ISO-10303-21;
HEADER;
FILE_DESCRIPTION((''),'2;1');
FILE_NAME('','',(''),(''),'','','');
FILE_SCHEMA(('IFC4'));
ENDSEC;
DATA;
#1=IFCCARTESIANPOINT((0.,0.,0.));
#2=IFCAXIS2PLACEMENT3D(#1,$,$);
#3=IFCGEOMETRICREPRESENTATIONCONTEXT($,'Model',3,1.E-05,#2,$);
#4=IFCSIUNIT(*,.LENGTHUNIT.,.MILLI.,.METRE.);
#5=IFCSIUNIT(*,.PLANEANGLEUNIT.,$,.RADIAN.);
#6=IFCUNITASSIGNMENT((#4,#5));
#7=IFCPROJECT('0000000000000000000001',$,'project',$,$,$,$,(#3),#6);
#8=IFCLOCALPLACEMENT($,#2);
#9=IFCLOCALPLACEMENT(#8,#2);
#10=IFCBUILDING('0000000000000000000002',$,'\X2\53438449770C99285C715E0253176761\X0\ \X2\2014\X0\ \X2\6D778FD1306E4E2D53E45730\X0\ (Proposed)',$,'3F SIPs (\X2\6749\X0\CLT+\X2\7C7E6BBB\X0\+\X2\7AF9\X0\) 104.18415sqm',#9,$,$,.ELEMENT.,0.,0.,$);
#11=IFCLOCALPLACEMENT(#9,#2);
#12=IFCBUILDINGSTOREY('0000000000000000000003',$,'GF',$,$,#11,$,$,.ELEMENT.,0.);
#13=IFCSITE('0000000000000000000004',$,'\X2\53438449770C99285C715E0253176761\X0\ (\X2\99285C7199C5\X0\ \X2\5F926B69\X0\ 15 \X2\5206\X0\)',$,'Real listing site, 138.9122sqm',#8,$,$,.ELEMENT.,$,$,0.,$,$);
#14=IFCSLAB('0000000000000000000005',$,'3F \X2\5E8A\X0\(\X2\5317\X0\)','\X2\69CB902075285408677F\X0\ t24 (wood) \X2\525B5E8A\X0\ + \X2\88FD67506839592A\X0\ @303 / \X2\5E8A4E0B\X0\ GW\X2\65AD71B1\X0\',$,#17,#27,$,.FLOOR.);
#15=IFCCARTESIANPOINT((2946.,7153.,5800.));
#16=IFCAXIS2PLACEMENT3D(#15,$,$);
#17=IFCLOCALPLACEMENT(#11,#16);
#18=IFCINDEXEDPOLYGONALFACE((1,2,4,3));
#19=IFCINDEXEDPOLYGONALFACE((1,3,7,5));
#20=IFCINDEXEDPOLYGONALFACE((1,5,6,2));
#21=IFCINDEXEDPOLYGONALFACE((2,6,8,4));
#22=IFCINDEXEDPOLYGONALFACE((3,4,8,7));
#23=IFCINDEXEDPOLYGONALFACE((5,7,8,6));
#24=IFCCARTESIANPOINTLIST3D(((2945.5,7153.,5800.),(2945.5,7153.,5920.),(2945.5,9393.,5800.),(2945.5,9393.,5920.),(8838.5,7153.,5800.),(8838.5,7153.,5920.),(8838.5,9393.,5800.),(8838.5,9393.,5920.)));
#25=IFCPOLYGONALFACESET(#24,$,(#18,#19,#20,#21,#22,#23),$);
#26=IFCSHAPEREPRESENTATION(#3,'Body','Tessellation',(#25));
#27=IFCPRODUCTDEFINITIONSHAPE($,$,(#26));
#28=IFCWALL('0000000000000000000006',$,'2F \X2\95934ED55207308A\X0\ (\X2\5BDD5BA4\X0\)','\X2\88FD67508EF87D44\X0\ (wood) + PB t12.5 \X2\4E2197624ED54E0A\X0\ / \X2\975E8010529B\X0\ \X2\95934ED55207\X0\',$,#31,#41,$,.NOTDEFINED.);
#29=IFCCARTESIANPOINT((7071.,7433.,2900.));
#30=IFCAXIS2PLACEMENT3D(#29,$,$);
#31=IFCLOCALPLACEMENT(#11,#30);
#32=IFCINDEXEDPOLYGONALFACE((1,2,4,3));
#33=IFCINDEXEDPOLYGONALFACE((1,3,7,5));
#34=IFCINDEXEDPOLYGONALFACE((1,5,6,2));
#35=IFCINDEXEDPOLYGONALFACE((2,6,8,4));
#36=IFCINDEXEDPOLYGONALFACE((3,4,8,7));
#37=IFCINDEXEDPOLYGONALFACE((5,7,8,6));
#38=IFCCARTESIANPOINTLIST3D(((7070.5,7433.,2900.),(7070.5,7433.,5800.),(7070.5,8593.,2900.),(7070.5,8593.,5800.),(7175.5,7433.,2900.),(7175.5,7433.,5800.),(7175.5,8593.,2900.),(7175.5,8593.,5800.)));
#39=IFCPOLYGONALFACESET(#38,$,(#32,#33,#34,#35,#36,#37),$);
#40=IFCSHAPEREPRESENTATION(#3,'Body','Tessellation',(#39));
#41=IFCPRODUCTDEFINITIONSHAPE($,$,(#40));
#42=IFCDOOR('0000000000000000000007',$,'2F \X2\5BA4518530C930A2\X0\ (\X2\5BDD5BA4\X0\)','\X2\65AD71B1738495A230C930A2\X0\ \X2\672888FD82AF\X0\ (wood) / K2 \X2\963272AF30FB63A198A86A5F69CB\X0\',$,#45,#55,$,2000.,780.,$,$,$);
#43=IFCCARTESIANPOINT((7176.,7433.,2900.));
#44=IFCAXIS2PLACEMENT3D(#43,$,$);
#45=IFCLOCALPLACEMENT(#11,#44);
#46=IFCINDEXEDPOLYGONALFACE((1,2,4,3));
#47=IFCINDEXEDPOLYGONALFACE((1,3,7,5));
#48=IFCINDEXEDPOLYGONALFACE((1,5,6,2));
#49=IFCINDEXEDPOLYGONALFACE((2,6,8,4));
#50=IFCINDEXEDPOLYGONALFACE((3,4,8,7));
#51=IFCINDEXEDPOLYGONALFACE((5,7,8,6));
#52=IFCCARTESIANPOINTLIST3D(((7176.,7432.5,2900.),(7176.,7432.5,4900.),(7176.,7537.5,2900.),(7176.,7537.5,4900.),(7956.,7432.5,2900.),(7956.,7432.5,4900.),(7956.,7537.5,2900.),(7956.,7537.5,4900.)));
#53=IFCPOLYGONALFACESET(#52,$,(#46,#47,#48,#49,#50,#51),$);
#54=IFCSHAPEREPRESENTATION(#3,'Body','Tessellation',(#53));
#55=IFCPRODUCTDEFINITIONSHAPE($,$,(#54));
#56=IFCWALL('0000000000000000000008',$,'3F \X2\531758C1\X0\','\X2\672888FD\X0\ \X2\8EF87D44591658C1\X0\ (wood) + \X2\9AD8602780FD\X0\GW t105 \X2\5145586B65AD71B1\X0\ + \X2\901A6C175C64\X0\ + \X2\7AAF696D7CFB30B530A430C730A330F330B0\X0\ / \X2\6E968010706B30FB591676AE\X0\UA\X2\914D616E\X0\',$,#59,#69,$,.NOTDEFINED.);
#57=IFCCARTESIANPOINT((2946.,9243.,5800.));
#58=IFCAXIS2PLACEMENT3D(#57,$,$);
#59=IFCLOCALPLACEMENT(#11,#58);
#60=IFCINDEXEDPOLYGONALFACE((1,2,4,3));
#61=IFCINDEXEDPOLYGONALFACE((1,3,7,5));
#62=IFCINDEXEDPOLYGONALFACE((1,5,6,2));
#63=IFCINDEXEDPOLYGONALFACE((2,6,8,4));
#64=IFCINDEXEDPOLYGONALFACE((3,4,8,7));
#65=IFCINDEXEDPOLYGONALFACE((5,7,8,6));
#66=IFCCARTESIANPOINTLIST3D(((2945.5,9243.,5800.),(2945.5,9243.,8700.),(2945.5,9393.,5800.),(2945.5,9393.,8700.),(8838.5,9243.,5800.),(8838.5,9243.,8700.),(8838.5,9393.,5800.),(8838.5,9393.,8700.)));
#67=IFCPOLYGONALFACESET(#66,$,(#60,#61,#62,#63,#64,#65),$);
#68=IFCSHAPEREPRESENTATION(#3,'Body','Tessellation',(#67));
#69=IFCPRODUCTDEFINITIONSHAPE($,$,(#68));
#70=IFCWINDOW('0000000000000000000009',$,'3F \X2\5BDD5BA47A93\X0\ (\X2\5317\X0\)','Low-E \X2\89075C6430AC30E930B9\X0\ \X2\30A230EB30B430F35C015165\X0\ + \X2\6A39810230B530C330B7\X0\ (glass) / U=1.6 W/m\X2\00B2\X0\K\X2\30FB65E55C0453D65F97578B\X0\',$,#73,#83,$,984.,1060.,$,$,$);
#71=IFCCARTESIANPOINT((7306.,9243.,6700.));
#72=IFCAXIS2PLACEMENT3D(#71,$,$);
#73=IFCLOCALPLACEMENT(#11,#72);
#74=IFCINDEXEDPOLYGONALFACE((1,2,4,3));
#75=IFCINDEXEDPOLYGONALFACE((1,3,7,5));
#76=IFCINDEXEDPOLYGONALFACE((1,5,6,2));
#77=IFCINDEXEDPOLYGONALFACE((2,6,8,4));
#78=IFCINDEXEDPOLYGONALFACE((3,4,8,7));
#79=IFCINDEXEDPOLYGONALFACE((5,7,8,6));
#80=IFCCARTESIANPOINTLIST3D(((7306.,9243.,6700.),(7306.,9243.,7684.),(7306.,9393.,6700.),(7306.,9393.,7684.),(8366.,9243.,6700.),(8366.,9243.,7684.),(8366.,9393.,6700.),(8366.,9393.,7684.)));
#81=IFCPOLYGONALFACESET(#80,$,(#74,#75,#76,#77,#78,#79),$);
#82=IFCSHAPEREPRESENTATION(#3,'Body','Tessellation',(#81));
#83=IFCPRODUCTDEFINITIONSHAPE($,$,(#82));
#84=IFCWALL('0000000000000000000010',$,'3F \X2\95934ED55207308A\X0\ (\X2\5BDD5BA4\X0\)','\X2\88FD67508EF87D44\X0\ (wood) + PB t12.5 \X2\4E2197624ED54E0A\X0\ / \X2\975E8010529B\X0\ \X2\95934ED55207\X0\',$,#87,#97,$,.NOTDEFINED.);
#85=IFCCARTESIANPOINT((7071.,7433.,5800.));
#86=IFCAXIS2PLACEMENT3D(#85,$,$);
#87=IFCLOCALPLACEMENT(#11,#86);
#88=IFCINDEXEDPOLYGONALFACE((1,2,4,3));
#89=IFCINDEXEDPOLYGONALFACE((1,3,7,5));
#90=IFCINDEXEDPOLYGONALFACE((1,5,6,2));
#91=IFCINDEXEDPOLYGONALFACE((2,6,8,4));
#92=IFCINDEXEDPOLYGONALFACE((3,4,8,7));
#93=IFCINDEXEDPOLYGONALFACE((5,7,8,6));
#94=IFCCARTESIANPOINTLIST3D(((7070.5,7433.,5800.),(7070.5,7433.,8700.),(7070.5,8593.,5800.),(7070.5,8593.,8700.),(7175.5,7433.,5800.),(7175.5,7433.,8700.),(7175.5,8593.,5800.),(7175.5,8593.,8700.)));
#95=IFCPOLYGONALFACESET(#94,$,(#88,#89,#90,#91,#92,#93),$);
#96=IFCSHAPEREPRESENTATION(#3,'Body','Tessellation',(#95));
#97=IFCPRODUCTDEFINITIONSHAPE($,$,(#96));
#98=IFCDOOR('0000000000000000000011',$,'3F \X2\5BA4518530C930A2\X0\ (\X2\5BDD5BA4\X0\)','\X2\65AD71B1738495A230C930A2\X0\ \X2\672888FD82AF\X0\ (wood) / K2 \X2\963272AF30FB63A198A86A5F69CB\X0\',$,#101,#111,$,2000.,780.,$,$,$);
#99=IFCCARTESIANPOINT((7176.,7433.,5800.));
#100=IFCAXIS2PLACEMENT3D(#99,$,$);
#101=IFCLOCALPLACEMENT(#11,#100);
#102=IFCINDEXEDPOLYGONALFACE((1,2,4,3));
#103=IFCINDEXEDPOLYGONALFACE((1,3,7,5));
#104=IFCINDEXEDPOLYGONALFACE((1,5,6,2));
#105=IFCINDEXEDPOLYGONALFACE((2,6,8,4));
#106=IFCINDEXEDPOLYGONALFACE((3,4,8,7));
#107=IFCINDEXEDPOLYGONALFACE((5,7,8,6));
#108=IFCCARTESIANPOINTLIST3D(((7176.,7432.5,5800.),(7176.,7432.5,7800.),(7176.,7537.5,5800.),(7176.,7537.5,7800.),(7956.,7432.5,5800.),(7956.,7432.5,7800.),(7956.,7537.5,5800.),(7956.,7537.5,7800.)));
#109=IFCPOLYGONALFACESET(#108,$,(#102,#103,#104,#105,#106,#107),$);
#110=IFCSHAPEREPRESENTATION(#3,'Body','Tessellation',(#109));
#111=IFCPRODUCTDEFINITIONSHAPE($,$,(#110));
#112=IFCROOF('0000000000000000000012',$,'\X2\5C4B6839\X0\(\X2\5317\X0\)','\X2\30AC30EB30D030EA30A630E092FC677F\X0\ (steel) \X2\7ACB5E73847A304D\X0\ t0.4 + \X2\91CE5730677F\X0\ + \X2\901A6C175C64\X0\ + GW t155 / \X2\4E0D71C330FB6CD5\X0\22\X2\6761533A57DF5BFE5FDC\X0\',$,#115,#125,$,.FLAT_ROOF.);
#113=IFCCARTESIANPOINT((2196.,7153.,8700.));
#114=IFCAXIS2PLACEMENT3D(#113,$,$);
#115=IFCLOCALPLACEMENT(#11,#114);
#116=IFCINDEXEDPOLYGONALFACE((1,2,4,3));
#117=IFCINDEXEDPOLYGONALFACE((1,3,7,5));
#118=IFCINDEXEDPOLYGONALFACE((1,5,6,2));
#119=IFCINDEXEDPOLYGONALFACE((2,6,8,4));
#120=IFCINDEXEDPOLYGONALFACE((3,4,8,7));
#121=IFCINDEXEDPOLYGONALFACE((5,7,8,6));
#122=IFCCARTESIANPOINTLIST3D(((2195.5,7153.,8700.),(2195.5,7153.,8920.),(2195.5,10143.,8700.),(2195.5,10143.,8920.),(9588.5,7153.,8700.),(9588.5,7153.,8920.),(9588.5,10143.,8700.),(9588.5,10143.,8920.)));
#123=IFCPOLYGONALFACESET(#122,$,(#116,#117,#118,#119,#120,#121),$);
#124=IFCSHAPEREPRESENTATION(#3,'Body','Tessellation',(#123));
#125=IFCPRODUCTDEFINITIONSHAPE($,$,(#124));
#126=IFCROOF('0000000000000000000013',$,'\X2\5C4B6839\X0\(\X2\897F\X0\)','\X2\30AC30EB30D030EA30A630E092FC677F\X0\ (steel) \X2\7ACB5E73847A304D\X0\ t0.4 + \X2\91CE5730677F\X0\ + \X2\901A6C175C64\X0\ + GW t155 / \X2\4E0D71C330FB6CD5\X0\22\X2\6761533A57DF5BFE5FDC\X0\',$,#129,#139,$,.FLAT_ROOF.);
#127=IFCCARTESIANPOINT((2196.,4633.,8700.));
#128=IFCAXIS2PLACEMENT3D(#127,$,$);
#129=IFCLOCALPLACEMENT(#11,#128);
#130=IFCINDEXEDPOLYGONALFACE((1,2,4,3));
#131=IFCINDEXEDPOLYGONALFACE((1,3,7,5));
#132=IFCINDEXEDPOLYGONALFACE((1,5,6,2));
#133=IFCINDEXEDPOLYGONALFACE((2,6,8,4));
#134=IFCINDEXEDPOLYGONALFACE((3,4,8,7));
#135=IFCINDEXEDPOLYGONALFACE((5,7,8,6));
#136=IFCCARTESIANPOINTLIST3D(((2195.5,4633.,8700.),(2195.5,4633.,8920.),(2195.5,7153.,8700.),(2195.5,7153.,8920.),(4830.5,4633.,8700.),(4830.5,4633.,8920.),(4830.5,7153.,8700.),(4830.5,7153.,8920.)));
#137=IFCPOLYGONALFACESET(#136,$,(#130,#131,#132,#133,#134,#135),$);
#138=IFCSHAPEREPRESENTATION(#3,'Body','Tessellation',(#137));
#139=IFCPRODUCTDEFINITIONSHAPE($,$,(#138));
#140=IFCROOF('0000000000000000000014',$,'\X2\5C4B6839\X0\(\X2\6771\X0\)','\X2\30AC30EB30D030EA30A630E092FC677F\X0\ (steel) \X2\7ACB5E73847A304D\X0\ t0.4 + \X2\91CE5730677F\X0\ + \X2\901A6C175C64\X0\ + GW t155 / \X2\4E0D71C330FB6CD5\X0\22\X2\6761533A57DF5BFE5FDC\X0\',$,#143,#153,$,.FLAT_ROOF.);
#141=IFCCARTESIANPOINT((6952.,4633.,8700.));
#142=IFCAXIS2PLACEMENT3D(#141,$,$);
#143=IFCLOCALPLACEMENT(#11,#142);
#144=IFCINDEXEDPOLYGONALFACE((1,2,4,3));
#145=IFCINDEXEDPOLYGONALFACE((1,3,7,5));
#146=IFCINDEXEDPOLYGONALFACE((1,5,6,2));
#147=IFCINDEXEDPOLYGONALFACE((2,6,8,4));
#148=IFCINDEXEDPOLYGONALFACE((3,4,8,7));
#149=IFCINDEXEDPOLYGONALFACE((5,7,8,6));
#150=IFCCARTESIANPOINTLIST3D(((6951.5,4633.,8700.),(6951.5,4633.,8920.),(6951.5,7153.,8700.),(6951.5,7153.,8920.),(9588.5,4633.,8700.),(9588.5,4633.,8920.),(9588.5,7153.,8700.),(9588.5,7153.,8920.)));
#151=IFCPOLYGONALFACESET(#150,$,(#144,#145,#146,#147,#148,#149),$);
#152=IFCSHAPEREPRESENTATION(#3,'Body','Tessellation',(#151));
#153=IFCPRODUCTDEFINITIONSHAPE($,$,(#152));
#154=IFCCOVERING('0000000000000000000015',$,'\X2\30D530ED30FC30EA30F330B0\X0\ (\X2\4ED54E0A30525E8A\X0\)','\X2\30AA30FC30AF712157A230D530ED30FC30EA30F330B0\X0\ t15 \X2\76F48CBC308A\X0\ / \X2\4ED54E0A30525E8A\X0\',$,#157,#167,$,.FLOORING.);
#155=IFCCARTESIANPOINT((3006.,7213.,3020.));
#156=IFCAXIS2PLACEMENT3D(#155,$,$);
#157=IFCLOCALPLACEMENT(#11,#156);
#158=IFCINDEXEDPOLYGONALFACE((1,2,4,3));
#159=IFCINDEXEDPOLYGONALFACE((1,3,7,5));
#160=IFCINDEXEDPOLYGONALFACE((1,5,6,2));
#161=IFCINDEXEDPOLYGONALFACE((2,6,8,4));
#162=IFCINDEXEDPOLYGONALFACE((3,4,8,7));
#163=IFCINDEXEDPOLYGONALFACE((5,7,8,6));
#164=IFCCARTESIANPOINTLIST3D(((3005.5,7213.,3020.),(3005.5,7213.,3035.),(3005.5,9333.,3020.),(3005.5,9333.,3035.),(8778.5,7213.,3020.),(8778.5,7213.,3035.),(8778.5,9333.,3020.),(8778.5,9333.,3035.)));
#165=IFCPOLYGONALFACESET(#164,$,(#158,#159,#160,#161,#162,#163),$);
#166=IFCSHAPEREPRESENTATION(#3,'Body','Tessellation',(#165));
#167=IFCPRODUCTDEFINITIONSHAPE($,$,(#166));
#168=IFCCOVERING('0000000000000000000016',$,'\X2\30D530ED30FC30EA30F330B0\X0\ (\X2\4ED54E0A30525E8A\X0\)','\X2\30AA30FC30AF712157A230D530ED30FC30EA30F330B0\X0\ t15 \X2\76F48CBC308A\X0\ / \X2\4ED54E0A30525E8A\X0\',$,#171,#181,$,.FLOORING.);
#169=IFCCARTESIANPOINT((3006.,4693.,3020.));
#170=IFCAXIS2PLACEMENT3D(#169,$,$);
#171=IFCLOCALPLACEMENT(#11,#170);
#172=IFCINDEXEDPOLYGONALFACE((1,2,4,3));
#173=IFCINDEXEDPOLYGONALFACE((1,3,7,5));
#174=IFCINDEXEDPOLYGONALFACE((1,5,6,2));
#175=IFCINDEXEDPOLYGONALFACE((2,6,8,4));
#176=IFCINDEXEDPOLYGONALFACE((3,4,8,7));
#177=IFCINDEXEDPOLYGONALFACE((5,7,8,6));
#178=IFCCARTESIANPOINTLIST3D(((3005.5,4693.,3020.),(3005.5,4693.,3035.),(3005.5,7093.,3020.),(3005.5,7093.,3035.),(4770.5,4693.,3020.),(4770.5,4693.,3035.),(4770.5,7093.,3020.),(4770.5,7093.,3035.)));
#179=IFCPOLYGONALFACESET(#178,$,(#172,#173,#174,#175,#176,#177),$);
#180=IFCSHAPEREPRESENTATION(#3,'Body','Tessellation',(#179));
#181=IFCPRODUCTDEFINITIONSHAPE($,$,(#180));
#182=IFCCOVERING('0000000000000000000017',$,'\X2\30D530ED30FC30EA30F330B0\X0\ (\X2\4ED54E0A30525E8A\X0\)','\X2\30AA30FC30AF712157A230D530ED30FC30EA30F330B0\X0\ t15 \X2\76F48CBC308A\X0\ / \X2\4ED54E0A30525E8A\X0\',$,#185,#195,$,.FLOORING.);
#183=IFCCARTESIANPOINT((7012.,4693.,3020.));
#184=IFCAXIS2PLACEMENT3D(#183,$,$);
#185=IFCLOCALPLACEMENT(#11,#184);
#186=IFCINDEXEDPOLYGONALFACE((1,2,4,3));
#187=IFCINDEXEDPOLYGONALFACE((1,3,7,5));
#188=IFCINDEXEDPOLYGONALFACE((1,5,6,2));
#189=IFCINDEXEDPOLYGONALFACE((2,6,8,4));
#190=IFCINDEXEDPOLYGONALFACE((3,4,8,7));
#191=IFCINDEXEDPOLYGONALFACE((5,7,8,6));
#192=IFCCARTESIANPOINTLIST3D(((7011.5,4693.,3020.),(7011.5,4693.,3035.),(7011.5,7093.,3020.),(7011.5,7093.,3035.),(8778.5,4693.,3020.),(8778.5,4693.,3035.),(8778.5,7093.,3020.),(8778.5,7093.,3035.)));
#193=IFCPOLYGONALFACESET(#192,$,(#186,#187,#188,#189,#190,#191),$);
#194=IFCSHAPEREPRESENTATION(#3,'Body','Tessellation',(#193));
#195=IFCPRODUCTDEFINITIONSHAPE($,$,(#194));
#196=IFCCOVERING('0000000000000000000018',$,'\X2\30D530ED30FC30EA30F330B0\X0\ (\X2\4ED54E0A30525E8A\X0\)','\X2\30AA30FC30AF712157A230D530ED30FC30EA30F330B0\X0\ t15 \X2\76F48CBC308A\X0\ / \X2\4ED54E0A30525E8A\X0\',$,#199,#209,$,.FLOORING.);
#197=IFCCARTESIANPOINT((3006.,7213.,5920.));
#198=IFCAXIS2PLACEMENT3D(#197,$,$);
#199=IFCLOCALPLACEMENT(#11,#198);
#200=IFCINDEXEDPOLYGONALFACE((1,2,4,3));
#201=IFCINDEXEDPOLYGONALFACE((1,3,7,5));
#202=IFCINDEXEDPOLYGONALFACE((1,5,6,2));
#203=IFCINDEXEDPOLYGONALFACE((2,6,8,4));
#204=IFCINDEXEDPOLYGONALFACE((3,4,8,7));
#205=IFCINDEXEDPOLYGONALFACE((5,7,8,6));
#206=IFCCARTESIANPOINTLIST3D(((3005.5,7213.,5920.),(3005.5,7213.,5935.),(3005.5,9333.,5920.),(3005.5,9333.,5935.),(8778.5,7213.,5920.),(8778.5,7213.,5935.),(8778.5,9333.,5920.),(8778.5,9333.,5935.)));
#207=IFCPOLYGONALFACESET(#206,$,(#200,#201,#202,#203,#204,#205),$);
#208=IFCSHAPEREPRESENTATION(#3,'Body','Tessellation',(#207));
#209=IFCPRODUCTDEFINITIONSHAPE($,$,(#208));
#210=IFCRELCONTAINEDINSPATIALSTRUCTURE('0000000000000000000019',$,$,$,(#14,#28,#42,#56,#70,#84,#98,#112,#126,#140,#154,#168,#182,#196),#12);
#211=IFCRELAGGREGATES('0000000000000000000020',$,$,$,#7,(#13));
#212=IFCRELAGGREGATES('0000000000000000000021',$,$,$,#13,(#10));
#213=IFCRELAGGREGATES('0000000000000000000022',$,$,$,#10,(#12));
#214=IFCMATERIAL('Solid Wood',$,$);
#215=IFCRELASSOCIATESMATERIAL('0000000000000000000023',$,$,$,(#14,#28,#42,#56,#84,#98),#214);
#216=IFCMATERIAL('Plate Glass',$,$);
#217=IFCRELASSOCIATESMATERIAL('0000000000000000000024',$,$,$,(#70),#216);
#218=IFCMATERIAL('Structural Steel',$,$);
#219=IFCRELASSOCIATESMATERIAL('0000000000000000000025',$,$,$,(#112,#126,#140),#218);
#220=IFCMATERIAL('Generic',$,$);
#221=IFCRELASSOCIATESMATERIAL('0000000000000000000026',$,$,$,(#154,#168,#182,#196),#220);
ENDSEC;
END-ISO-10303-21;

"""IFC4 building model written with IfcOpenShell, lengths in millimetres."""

from ifc_helpers import new_model, si_unit, frame, frame_2d, origin, place, context, project, spatial, rectangle, extrude, material, element, fill, save


model = new_model("IFC4")

# Units and contexts
model_context = context("Model", 3, precision=1e-05, world=origin())
ifc_project = project(units=[si_unit("LENGTHUNIT", "METRE", prefix="MILLI"), si_unit("PLANEANGLEUNIT", "RADIAN")], contexts=[model_context])

# Site, building, storey
site_placement = place(None, origin())
site = spatial("IfcSite", under=ifc_project, at=site_placement, Name="千葉県館山市北条 (館山駅 徒歩 15 分)", ObjectType="Real listing site, 138.9122sqm", CompositionType="ELEMENT", RefElevation=0.0)
building_placement = place(site_placement, origin())
building = spatial("IfcBuilding", under=site, at=building_placement, Name="千葉県館山市北条 — 海近の中古地 (Proposed)", ObjectType="3F SIPs (杉CLT+籾殻+竹) 104.18415sqm", CompositionType="ELEMENT", ElevationOfRefHeight=0.0, ElevationOfTerrain=0.0)
storey_placement = place(building_placement, origin())
storey = spatial("IfcBuildingStorey", under=building, at=storey_placement, Name="GF", CompositionType="ELEMENT", Elevation=0.0)

# Slab
ifc_material_1 = material(Name="Solid Wood")
slab_placement = place(storey_placement, frame((2946.0, 7153.0, 5800.0)))
element("IfcSlab", 1, at=slab_placement, inside=storey, material=ifc_material_1, Name="3F 床(北)", Description="構造用合板 t24 (wood) 剛床 + 製材根太 @303 / 床下 GW断熱", PredefinedType="FLOOR", context=model_context, shape_type="SweptSolid", body=[
    extrude(rectangle(XDim=5893.0, YDim=2240.0, at=frame_2d((2946.0, 1120.0))), frame((2946.0, 7153.0, 5800.0)), (0.0, 0.0, 1.0), 120.0),
])

# Wall
wall_1_placement = place(storey_placement, frame((7071.0, 7433.0, 2900.0)))
element("IfcWall", 2, at=wall_1_placement, inside=storey, material=ifc_material_1, Name="2F 間仕切り (寝室)", Description="製材軸組 (wood) + PB t12.5 両面仕上 / 非耐力 間仕切", PredefinedType="NOTDEFINED", context=model_context, shape_type="SweptSolid", body=[
    extrude(rectangle(XDim=105.0, YDim=1160.0, at=frame_2d((52.0, 580.0))), frame((7071.0, 7433.0, 2900.0)), (0.0, 0.0, 1.0), 2900.0),
])

# Door
door_1_placement = place(storey_placement, frame((7176.0, 7433.0, 2900.0)))
element("IfcDoor", 3, at=door_1_placement, inside=storey, material=ifc_material_1, Name="2F 室内ドア (寝室)", Description="断熱玄関ドア 木製芯 (wood) / K2 防犯・採風機構", OverallHeight=2000.0, OverallWidth=780.0, context=model_context, shape_type="SweptSolid", body=[
    extrude(rectangle(XDim=780.0, YDim=105.0, at=frame_2d((390.0, 52.0))), frame((7176.0, 7433.0, 2900.0)), (0.0, 0.0, 1.0), 2000.0),
])

# Wall, opening, window
wall_2_placement = place(storey_placement, frame((2946.0, 9243.0, 5800.0)))
wall_2 = element("IfcWall", 4, at=wall_2_placement, inside=storey, material=ifc_material_1, Name="3F 北壁", Description="木製 軸組外壁 (wood) + 高性能GW t105 充填断熱 + 通気層 + 窯業系サイディング / 準耐火・外皮UA配慮", PredefinedType="NOTDEFINED", context=model_context, shape_type="SweptSolid", body=[
    extrude(rectangle(XDim=5893.0, YDim=150.0, at=frame_2d((2946.0, 75.0))), frame((2946.0, 9243.0, 5800.0)), (0.0, 0.0, 1.0), 2900.0),
])
opening_1_placement = place(storey_placement, frame((7306.0, 9243.0, 6700.0)))
opening_1 = element("IfcOpeningElement", 5, at=opening_1_placement, cuts=wall_2, PredefinedType="NOTDEFINED", context=model_context, shape_type="SweptSolid", body=[
    extrude(rectangle(XDim=1060.0, YDim=150.0, at=frame_2d((530.0, 75.0))), frame((7306.0, 9243.0, 6700.0)), (0.0, 0.0, 1.0), 984.0),
])
ifc_material_2 = material(Name="Plate Glass")
window_1_placement = place(storey_placement, frame((7306.0, 9243.0, 6700.0)))
window_1 = element("IfcWindow", 6, at=window_1_placement, inside=storey, material=ifc_material_2, Name="3F 寝室窓 (北)", Description="Low-E 複層ガラス アルゴン封入 + 樹脂サッシ (glass) / U=1.6 W/m²K・日射取得型", OverallHeight=984.0, OverallWidth=1060.0, context=model_context, shape_type="SweptSolid", body=[
    extrude(rectangle(XDim=1060.0, YDim=150.0, at=frame_2d((530.0, 75.0))), frame((7306.0, 9243.0, 6700.0)), (0.0, 0.0, 1.0), 984.0),
])
fill(opening_1, window_1)

# Wall
wall_3_placement = place(storey_placement, frame((7071.0, 7433.0, 5800.0)))
element("IfcWall", 7, at=wall_3_placement, inside=storey, material=ifc_material_1, Name="3F 間仕切り (寝室)", Description="製材軸組 (wood) + PB t12.5 両面仕上 / 非耐力 間仕切", PredefinedType="NOTDEFINED", context=model_context, shape_type="SweptSolid", body=[
    extrude(rectangle(XDim=105.0, YDim=1160.0, at=frame_2d((52.0, 580.0))), frame((7071.0, 7433.0, 5800.0)), (0.0, 0.0, 1.0), 2900.0),
])

# Door
door_2_placement = place(storey_placement, frame((7176.0, 7433.0, 5800.0)))
element("IfcDoor", 8, at=door_2_placement, inside=storey, material=ifc_material_1, Name="3F 室内ドア (寝室)", Description="断熱玄関ドア 木製芯 (wood) / K2 防犯・採風機構", OverallHeight=2000.0, OverallWidth=780.0, context=model_context, shape_type="SweptSolid", body=[
    extrude(rectangle(XDim=780.0, YDim=105.0, at=frame_2d((390.0, 52.0))), frame((7176.0, 7433.0, 5800.0)), (0.0, 0.0, 1.0), 2000.0),
])

# Roofs
ifc_material_3 = material(Name="Structural Steel")
for number, where, name in (
    (9, (2196.0, 7153.0, 8700.0), "屋根(北)"),
):
    element("IfcRoof", number, at=place(storey_placement, frame(where)), inside=storey, material=ifc_material_3, Name=name, Description="ガルバリウム鋼板 (steel) 立平葺き t0.4 + 野地板 + 通気層 + GW t155 / 不燃・法22条区域対応", PredefinedType="FLAT_ROOF", context=model_context, shape_type="SweptSolid", body=[
        extrude(rectangle(XDim=7393.0, YDim=2990.0, at=frame_2d((3696.0, 1495.0))), frame((2196.0, 7153.0, 8700.0)), (0.0, 0.0, 1.0), 220.0),
    ])
roof_1_placement = place(storey_placement, frame((2196.0, 4633.0, 8700.0)))
element("IfcRoof", 10, at=roof_1_placement, inside=storey, material=ifc_material_3, Name="屋根(西)", Description="ガルバリウム鋼板 (steel) 立平葺き t0.4 + 野地板 + 通気層 + GW t155 / 不燃・法22条区域対応", PredefinedType="FLAT_ROOF", context=model_context, shape_type="SweptSolid", body=[
    extrude(rectangle(XDim=2635.0, YDim=2520.0, at=frame_2d((1317.0, 1260.0))), frame((2196.0, 4633.0, 8700.0)), (0.0, 0.0, 1.0), 220.0),
])
roof_2_placement = place(storey_placement, frame((6952.0, 4633.0, 8700.0)))
element("IfcRoof", 11, at=roof_2_placement, inside=storey, material=ifc_material_3, Name="屋根(東)", Description="ガルバリウム鋼板 (steel) 立平葺き t0.4 + 野地板 + 通気層 + GW t155 / 不燃・法22条区域対応", PredefinedType="FLAT_ROOF", context=model_context, shape_type="SweptSolid", body=[
    extrude(rectangle(XDim=2637.0, YDim=2520.0, at=frame_2d((1318.0, 1260.0))), frame((6952.0, 4633.0, 8700.0)), (0.0, 0.0, 1.0), 220.0),
])

# Coverings
ifc_material_4 = material(Name="Generic")
covering_1_placement = place(storey_placement, frame((3006.0, 7213.0, 3020.0)))
element("IfcCovering", 12, at=covering_1_placement, inside=storey, material=ifc_material_4, Name="フローリング (仕上げ床)", Description="オーク無垢フローリング t15 直貼り / 仕上げ床", PredefinedType="FLOORING", context=model_context, shape_type="SweptSolid", body=[
    extrude(rectangle(XDim=5773.0, YDim=2120.0, at=frame_2d((2886.0, 1060.0))), frame((3006.0, 7213.0, 3020.0)), (0.0, 0.0, 1.0), 15.0),
])
covering_2_placement = place(storey_placement, frame((3006.0, 4693.0, 3020.0)))
element("IfcCovering", 13, at=covering_2_placement, inside=storey, material=ifc_material_4, Name="フローリング (仕上げ床)", Description="オーク無垢フローリング t15 直貼り / 仕上げ床", PredefinedType="FLOORING", context=model_context, shape_type="SweptSolid", body=[
    extrude(rectangle(XDim=1765.0, YDim=2400.0, at=frame_2d((882.0, 1200.0))), frame((3006.0, 4693.0, 3020.0)), (0.0, 0.0, 1.0), 15.0),
])
covering_3_placement = place(storey_placement, frame((7012.0, 4693.0, 3020.0)))
element("IfcCovering", 14, at=covering_3_placement, inside=storey, material=ifc_material_4, Name="フローリング (仕上げ床)", Description="オーク無垢フローリング t15 直貼り / 仕上げ床", PredefinedType="FLOORING", context=model_context, shape_type="SweptSolid", body=[
    extrude(rectangle(XDim=1767.0, YDim=2400.0, at=frame_2d((883.0, 1200.0))), frame((7012.0, 4693.0, 3020.0)), (0.0, 0.0, 1.0), 15.0),
])
covering_4_placement = place(storey_placement, frame((3006.0, 7213.0, 5920.0)))
element("IfcCovering", 15, at=covering_4_placement, inside=storey, material=ifc_material_4, Name="フローリング (仕上げ床)", Description="オーク無垢フローリング t15 直貼り / 仕上げ床", PredefinedType="FLOORING", context=model_context, shape_type="SweptSolid", body=[
    extrude(rectangle(XDim=5773.0, YDim=2120.0, at=frame_2d((2886.0, 1060.0))), frame((3006.0, 7213.0, 5920.0)), (0.0, 0.0, 1.0), 15.0),
])

save(model, "model.ifc")
